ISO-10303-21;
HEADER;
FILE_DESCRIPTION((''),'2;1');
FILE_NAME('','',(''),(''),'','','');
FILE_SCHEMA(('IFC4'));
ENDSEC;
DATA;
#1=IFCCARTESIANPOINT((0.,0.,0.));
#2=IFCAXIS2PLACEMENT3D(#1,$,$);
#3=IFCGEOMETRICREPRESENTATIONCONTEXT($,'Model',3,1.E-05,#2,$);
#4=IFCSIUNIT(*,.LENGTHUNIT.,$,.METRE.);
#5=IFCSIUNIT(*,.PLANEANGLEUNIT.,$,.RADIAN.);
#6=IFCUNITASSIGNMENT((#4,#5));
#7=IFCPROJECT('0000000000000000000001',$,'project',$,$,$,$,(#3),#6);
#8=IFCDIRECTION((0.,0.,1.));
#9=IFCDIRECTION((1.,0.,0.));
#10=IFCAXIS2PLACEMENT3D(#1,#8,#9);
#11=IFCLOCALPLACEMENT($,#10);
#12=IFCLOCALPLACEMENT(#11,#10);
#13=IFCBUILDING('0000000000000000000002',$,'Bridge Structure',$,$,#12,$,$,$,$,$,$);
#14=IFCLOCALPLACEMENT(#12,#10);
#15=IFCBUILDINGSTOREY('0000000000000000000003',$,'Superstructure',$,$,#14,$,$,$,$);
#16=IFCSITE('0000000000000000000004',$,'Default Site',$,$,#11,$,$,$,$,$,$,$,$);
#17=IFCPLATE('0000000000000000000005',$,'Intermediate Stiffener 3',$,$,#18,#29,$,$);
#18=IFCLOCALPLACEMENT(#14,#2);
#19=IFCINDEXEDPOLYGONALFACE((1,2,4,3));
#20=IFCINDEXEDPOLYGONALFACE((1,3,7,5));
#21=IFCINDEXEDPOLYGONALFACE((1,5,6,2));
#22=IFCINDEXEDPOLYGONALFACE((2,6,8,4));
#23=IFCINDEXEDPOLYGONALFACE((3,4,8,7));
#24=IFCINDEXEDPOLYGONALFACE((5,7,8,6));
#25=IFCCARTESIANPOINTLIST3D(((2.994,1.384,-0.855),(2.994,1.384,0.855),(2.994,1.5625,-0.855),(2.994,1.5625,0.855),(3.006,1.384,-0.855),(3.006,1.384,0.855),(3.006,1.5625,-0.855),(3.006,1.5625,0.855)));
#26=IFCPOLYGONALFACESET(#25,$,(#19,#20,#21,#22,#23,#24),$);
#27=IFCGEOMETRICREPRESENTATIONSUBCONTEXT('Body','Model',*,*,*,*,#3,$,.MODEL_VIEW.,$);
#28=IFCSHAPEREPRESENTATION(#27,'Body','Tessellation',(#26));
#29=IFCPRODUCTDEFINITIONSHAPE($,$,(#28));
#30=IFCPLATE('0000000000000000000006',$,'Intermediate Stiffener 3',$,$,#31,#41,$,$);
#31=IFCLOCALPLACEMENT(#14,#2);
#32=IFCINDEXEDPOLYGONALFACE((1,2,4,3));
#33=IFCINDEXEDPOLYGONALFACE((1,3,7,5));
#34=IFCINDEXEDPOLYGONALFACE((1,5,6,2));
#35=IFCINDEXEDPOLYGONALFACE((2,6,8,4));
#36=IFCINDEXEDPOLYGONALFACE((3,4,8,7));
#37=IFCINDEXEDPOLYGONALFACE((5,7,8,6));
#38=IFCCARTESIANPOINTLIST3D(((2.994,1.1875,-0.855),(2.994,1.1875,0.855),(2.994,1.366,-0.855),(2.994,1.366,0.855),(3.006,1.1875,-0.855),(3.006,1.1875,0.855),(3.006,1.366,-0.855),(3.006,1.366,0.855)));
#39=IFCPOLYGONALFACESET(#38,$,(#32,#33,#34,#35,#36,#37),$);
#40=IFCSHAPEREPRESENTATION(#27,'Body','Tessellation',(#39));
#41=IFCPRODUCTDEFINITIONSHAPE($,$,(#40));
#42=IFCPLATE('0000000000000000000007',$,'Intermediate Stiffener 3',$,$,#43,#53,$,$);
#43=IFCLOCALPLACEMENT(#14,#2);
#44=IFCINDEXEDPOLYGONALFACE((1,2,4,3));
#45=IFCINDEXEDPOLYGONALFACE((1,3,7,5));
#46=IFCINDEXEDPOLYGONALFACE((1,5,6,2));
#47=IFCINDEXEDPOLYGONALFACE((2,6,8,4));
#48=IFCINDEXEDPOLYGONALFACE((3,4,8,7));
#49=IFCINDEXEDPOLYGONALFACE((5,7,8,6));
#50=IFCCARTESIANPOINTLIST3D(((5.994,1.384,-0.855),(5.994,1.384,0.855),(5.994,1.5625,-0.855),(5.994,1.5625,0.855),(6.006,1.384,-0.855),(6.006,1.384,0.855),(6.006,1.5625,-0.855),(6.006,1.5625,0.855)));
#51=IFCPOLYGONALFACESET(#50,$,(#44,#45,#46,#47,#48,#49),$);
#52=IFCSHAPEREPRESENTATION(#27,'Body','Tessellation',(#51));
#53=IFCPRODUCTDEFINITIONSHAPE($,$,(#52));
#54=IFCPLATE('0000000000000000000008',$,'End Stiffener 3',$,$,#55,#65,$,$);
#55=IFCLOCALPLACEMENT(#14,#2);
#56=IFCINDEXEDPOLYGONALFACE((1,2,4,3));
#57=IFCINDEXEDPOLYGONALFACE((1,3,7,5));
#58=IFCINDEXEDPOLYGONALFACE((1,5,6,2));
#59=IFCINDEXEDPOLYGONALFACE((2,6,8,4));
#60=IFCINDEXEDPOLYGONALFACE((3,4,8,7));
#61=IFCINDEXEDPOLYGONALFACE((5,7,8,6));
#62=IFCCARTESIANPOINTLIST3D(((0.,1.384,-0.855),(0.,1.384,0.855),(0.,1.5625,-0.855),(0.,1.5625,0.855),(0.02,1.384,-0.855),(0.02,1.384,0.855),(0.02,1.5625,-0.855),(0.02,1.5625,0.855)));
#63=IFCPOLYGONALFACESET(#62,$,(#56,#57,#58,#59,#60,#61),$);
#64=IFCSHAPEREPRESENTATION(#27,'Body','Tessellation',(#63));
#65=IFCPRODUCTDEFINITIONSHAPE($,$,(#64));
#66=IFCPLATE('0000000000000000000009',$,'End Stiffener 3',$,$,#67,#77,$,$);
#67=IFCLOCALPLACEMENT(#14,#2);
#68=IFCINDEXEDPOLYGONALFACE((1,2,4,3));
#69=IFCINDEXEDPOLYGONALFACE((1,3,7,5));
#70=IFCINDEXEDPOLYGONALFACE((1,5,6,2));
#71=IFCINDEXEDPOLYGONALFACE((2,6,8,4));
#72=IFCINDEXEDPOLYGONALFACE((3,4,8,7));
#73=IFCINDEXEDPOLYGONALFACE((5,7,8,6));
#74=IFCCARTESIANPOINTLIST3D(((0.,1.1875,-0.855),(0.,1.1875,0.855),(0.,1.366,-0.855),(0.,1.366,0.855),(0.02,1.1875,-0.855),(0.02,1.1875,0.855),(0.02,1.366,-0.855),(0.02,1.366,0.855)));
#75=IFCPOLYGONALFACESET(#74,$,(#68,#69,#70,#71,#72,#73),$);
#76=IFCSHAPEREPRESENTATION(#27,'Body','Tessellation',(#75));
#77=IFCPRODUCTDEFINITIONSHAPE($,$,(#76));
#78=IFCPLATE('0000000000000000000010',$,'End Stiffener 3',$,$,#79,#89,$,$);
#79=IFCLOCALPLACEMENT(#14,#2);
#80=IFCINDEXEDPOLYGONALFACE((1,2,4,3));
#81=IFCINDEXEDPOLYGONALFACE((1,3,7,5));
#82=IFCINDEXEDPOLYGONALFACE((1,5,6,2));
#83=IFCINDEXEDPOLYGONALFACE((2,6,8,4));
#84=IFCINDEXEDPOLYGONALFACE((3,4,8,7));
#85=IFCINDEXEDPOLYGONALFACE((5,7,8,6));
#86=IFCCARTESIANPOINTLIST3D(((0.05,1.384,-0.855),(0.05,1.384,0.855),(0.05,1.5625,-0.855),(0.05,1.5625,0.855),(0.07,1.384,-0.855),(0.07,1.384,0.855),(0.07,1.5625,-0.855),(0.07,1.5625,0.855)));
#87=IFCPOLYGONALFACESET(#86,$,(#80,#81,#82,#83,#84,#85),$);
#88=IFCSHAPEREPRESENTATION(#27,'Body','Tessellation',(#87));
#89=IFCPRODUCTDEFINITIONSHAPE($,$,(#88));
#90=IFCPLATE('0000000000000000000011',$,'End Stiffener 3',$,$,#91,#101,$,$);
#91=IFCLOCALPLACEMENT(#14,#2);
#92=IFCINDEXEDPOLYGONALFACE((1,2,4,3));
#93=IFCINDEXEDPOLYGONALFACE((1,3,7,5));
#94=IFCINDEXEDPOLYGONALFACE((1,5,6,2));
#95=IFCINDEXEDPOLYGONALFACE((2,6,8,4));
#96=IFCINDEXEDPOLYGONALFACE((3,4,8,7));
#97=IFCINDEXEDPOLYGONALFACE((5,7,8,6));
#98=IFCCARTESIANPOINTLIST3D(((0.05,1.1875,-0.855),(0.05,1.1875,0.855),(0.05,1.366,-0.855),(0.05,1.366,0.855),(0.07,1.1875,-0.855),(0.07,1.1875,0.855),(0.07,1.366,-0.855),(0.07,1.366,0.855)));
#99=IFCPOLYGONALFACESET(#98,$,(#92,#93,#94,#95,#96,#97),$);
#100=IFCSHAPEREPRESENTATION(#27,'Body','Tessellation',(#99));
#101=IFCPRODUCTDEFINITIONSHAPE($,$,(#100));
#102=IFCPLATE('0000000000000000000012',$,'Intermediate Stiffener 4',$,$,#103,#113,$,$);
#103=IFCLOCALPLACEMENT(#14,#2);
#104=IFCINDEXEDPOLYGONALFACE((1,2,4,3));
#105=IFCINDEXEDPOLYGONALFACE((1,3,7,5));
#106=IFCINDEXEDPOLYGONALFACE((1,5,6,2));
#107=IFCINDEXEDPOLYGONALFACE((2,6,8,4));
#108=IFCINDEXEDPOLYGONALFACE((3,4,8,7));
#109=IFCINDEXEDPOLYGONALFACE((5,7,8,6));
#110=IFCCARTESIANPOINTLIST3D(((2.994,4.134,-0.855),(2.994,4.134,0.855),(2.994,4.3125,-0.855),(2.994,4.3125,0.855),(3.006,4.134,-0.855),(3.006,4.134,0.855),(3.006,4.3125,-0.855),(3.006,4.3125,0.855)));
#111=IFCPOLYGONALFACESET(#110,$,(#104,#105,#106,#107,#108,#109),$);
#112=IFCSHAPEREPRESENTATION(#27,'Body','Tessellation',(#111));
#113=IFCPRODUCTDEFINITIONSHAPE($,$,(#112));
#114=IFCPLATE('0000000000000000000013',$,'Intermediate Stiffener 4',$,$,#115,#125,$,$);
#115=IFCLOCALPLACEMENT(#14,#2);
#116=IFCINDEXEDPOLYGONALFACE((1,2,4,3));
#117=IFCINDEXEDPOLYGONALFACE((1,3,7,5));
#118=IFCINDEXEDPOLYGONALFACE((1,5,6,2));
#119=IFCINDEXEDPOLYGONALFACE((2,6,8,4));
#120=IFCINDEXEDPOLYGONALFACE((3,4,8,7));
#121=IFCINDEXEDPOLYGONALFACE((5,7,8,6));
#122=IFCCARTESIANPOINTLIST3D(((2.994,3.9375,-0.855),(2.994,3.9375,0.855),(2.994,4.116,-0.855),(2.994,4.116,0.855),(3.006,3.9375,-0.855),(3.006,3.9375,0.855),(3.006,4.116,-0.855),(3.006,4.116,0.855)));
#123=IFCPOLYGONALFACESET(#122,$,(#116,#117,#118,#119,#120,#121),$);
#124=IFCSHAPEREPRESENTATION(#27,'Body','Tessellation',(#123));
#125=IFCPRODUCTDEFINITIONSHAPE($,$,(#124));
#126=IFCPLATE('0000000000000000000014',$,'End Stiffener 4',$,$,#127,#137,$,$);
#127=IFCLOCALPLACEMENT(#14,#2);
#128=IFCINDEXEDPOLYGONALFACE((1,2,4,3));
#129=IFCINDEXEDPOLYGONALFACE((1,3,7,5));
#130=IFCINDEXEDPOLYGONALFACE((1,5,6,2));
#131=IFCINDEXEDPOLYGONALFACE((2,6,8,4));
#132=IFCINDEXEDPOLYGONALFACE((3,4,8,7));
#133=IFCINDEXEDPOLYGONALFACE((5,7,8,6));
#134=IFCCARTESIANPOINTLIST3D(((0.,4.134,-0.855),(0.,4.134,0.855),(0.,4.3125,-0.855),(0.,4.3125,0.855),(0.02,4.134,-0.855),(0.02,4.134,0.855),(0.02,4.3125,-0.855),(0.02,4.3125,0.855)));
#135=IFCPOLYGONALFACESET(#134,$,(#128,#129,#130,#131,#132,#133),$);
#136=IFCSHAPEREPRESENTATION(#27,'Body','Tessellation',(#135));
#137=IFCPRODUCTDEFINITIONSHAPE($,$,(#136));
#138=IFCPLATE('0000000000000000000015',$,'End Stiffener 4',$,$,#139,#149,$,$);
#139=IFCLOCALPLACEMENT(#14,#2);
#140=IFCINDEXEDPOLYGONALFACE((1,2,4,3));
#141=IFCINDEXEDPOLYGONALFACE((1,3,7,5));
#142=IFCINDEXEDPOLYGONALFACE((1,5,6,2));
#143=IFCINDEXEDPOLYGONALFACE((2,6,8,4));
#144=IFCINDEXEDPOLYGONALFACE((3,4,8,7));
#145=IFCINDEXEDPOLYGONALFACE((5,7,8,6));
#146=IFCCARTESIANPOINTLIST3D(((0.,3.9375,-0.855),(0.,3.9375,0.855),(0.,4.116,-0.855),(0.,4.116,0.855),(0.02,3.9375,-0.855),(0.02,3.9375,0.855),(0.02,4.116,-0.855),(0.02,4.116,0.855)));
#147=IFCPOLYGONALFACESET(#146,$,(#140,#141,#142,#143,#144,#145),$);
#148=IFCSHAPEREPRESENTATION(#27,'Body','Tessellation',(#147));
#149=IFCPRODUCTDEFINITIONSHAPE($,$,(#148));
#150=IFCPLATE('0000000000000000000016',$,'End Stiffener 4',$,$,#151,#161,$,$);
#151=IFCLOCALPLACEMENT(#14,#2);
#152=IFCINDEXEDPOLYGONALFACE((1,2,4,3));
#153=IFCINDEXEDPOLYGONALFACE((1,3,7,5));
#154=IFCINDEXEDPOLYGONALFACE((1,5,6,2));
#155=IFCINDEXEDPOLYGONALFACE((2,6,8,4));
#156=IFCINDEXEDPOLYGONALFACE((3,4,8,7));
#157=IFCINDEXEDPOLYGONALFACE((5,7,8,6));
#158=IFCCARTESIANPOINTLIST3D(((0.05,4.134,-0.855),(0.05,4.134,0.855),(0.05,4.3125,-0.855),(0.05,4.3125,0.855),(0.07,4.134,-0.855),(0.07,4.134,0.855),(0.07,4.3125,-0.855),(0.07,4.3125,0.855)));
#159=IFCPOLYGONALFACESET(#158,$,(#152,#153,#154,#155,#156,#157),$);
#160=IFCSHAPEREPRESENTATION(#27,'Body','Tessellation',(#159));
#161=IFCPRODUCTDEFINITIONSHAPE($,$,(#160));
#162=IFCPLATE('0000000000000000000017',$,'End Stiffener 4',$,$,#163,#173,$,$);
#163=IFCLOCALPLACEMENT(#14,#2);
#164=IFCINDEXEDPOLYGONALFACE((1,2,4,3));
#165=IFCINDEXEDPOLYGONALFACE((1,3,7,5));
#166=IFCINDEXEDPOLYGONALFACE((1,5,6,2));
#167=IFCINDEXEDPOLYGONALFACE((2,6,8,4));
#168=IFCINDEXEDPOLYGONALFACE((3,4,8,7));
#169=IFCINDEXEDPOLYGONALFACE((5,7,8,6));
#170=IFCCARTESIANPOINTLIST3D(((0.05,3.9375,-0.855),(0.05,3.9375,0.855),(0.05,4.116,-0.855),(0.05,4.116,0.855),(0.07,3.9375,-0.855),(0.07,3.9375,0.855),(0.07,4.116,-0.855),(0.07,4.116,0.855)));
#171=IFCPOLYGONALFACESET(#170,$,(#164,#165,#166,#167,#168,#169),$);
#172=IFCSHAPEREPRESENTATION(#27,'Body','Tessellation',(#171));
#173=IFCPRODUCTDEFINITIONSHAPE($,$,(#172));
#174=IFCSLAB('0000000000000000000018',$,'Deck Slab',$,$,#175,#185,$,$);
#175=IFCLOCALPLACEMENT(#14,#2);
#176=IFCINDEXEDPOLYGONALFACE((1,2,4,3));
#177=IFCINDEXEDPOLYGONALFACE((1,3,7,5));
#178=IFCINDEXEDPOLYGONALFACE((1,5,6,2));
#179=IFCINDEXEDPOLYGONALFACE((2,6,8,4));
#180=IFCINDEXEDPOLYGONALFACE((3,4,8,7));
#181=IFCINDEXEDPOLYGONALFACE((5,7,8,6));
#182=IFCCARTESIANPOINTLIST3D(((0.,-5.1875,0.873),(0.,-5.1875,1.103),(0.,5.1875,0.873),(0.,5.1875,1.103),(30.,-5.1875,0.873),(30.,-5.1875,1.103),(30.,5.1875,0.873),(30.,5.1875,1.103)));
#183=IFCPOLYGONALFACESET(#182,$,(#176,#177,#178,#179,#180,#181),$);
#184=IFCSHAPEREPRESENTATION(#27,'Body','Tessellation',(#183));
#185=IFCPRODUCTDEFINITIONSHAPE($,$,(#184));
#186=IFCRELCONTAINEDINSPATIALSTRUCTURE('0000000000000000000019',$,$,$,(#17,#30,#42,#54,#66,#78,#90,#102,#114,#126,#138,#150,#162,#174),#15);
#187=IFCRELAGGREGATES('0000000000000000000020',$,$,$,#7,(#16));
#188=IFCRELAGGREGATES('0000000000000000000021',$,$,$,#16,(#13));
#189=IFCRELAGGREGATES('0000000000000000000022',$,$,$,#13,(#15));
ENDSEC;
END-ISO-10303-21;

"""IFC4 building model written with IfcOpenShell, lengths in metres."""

from ifc_helpers import new_model, si_unit, frame, origin, origin_with_axes, origin_2d_with_axis, place, context, subcontext, project, spatial, polyline, rectangle, outline, extrude, element, save


model = new_model("IFC4")

# Units and contexts
model_context = context("Model", 3, precision=1e-05, world=origin())
body_context = subcontext(model_context, "Body", "Model", "MODEL_VIEW")
ifc_project = project(units=[si_unit("LENGTHUNIT", "METRE"), si_unit("PLANEANGLEUNIT", "RADIAN")], contexts=[model_context])

# Site, building, storey
site_placement = place(None, origin_with_axes())
site = spatial("IfcSite", under=ifc_project, at=site_placement, Name="Default Site")
building_placement = place(site_placement, origin_with_axes())
building = spatial("IfcBuilding", under=site, at=building_placement, Name="Bridge Structure")
storey_placement = place(building_placement, origin_with_axes())
storey = spatial("IfcBuildingStorey", under=building, at=storey_placement, Name="Superstructure")

# Plates
for number, where, z_axis, x_axis, name in (
    (1, (3.0, 1.4732, -0.855), (0.0, 0.0, 1.0), (1.0, 0.0, 0.0), "Intermediate Stiffener 3"),
    (2, (3.0, 1.2768, -0.855), (0.0, 0.0, 1.0), (1.0, 0.0, 0.0), "Intermediate Stiffener 3"),
    (3, (6.0, 1.4732, -0.855), (0.0, 0.0, 1.0), (1.0, 0.0, 0.0), "Intermediate Stiffener 3"),
):
    element("IfcPlate", number, at=place(storey_placement, frame(where, z_axis=z_axis, x_axis=x_axis)), inside=storey, Name=name, context=body_context, shape_type="SweptSolid", body=[
        extrude(rectangle(XDim=0.012, YDim=0.1785, at=origin_2d_with_axis()), origin_with_axes(), (0.0, 0.0, 1.0), 1.71),
    ])
for number, where, z_axis, x_axis, name in (
    (4, (0.01, 1.4732, -0.855), (0.0, 0.0, 1.0), (1.0, 0.0, 0.0), "End Stiffener 3"),
    (5, (0.01, 1.2768, -0.855), (0.0, 0.0, 1.0), (1.0, 0.0, 0.0), "End Stiffener 3"),
    (6, (0.06, 1.4732, -0.855), (0.0, 0.0, 1.0), (1.0, 0.0, 0.0), "End Stiffener 3"),
    (7, (0.06, 1.2768, -0.855), (0.0, 0.0, 1.0), (1.0, 0.0, 0.0), "End Stiffener 3"),
):
    element("IfcPlate", number, at=place(storey_placement, frame(where, z_axis=z_axis, x_axis=x_axis)), inside=storey, Name=name, context=body_context, shape_type="SweptSolid", body=[
        extrude(rectangle(XDim=0.02, YDim=0.1785, at=origin_2d_with_axis()), origin_with_axes(), (0.0, 0.0, 1.0), 1.71),
    ])
for number, where, z_axis, x_axis, name in (
    (8, (3.0, 4.2233, -0.855), (0.0, 0.0, 1.0), (1.0, 0.0, 0.0), "Intermediate Stiffener 4"),
    (9, (3.0, 4.0267, -0.855), (0.0, 0.0, 1.0), (1.0, 0.0, 0.0), "Intermediate Stiffener 4"),
):
    element("IfcPlate", number, at=place(storey_placement, frame(where, z_axis=z_axis, x_axis=x_axis)), inside=storey, Name=name, context=body_context, shape_type="SweptSolid", body=[
        extrude(rectangle(XDim=0.012, YDim=0.1785, at=origin_2d_with_axis()), origin_with_axes(), (0.0, 0.0, 1.0), 1.71),
    ])
for number, where, z_axis, x_axis, name in (
    (10, (0.01, 4.2233, -0.855), (0.0, 0.0, 1.0), (1.0, 0.0, 0.0), "End Stiffener 4"),
    (11, (0.01, 4.0267, -0.855), (0.0, 0.0, 1.0), (1.0, 0.0, 0.0), "End Stiffener 4"),
    (12, (0.06, 4.2233, -0.855), (0.0, 0.0, 1.0), (1.0, 0.0, 0.0), "End Stiffener 4"),
    (13, (0.06, 4.0267, -0.855), (0.0, 0.0, 1.0), (1.0, 0.0, 0.0), "End Stiffener 4"),
):
    element("IfcPlate", number, at=place(storey_placement, frame(where, z_axis=z_axis, x_axis=x_axis)), inside=storey, Name=name, context=body_context, shape_type="SweptSolid", body=[
        extrude(rectangle(XDim=0.02, YDim=0.1785, at=origin_2d_with_axis()), origin_with_axes(), (0.0, 0.0, 1.0), 1.71),
    ])

# Slab
slab_placement = place(storey_placement, frame((0.0, 0.0, 0.873), z_axis=(0.0, 0.0, 1.0), x_axis=(1.0, 0.0, 0.0)))
element("IfcSlab", 14, at=slab_placement, inside=storey, Name="Deck Slab", context=body_context, shape_type="SweptSolid", body=[
    extrude(outline(polyline([(0.0, -5.1875), (30.0, -5.1875), (30.0, 5.1875), (0.0, 5.1875), (0.0, -5.1875)])), origin_with_axes(), (0.0, 0.0, 1.0), 0.23),
])

save(model, "model.ifc")
